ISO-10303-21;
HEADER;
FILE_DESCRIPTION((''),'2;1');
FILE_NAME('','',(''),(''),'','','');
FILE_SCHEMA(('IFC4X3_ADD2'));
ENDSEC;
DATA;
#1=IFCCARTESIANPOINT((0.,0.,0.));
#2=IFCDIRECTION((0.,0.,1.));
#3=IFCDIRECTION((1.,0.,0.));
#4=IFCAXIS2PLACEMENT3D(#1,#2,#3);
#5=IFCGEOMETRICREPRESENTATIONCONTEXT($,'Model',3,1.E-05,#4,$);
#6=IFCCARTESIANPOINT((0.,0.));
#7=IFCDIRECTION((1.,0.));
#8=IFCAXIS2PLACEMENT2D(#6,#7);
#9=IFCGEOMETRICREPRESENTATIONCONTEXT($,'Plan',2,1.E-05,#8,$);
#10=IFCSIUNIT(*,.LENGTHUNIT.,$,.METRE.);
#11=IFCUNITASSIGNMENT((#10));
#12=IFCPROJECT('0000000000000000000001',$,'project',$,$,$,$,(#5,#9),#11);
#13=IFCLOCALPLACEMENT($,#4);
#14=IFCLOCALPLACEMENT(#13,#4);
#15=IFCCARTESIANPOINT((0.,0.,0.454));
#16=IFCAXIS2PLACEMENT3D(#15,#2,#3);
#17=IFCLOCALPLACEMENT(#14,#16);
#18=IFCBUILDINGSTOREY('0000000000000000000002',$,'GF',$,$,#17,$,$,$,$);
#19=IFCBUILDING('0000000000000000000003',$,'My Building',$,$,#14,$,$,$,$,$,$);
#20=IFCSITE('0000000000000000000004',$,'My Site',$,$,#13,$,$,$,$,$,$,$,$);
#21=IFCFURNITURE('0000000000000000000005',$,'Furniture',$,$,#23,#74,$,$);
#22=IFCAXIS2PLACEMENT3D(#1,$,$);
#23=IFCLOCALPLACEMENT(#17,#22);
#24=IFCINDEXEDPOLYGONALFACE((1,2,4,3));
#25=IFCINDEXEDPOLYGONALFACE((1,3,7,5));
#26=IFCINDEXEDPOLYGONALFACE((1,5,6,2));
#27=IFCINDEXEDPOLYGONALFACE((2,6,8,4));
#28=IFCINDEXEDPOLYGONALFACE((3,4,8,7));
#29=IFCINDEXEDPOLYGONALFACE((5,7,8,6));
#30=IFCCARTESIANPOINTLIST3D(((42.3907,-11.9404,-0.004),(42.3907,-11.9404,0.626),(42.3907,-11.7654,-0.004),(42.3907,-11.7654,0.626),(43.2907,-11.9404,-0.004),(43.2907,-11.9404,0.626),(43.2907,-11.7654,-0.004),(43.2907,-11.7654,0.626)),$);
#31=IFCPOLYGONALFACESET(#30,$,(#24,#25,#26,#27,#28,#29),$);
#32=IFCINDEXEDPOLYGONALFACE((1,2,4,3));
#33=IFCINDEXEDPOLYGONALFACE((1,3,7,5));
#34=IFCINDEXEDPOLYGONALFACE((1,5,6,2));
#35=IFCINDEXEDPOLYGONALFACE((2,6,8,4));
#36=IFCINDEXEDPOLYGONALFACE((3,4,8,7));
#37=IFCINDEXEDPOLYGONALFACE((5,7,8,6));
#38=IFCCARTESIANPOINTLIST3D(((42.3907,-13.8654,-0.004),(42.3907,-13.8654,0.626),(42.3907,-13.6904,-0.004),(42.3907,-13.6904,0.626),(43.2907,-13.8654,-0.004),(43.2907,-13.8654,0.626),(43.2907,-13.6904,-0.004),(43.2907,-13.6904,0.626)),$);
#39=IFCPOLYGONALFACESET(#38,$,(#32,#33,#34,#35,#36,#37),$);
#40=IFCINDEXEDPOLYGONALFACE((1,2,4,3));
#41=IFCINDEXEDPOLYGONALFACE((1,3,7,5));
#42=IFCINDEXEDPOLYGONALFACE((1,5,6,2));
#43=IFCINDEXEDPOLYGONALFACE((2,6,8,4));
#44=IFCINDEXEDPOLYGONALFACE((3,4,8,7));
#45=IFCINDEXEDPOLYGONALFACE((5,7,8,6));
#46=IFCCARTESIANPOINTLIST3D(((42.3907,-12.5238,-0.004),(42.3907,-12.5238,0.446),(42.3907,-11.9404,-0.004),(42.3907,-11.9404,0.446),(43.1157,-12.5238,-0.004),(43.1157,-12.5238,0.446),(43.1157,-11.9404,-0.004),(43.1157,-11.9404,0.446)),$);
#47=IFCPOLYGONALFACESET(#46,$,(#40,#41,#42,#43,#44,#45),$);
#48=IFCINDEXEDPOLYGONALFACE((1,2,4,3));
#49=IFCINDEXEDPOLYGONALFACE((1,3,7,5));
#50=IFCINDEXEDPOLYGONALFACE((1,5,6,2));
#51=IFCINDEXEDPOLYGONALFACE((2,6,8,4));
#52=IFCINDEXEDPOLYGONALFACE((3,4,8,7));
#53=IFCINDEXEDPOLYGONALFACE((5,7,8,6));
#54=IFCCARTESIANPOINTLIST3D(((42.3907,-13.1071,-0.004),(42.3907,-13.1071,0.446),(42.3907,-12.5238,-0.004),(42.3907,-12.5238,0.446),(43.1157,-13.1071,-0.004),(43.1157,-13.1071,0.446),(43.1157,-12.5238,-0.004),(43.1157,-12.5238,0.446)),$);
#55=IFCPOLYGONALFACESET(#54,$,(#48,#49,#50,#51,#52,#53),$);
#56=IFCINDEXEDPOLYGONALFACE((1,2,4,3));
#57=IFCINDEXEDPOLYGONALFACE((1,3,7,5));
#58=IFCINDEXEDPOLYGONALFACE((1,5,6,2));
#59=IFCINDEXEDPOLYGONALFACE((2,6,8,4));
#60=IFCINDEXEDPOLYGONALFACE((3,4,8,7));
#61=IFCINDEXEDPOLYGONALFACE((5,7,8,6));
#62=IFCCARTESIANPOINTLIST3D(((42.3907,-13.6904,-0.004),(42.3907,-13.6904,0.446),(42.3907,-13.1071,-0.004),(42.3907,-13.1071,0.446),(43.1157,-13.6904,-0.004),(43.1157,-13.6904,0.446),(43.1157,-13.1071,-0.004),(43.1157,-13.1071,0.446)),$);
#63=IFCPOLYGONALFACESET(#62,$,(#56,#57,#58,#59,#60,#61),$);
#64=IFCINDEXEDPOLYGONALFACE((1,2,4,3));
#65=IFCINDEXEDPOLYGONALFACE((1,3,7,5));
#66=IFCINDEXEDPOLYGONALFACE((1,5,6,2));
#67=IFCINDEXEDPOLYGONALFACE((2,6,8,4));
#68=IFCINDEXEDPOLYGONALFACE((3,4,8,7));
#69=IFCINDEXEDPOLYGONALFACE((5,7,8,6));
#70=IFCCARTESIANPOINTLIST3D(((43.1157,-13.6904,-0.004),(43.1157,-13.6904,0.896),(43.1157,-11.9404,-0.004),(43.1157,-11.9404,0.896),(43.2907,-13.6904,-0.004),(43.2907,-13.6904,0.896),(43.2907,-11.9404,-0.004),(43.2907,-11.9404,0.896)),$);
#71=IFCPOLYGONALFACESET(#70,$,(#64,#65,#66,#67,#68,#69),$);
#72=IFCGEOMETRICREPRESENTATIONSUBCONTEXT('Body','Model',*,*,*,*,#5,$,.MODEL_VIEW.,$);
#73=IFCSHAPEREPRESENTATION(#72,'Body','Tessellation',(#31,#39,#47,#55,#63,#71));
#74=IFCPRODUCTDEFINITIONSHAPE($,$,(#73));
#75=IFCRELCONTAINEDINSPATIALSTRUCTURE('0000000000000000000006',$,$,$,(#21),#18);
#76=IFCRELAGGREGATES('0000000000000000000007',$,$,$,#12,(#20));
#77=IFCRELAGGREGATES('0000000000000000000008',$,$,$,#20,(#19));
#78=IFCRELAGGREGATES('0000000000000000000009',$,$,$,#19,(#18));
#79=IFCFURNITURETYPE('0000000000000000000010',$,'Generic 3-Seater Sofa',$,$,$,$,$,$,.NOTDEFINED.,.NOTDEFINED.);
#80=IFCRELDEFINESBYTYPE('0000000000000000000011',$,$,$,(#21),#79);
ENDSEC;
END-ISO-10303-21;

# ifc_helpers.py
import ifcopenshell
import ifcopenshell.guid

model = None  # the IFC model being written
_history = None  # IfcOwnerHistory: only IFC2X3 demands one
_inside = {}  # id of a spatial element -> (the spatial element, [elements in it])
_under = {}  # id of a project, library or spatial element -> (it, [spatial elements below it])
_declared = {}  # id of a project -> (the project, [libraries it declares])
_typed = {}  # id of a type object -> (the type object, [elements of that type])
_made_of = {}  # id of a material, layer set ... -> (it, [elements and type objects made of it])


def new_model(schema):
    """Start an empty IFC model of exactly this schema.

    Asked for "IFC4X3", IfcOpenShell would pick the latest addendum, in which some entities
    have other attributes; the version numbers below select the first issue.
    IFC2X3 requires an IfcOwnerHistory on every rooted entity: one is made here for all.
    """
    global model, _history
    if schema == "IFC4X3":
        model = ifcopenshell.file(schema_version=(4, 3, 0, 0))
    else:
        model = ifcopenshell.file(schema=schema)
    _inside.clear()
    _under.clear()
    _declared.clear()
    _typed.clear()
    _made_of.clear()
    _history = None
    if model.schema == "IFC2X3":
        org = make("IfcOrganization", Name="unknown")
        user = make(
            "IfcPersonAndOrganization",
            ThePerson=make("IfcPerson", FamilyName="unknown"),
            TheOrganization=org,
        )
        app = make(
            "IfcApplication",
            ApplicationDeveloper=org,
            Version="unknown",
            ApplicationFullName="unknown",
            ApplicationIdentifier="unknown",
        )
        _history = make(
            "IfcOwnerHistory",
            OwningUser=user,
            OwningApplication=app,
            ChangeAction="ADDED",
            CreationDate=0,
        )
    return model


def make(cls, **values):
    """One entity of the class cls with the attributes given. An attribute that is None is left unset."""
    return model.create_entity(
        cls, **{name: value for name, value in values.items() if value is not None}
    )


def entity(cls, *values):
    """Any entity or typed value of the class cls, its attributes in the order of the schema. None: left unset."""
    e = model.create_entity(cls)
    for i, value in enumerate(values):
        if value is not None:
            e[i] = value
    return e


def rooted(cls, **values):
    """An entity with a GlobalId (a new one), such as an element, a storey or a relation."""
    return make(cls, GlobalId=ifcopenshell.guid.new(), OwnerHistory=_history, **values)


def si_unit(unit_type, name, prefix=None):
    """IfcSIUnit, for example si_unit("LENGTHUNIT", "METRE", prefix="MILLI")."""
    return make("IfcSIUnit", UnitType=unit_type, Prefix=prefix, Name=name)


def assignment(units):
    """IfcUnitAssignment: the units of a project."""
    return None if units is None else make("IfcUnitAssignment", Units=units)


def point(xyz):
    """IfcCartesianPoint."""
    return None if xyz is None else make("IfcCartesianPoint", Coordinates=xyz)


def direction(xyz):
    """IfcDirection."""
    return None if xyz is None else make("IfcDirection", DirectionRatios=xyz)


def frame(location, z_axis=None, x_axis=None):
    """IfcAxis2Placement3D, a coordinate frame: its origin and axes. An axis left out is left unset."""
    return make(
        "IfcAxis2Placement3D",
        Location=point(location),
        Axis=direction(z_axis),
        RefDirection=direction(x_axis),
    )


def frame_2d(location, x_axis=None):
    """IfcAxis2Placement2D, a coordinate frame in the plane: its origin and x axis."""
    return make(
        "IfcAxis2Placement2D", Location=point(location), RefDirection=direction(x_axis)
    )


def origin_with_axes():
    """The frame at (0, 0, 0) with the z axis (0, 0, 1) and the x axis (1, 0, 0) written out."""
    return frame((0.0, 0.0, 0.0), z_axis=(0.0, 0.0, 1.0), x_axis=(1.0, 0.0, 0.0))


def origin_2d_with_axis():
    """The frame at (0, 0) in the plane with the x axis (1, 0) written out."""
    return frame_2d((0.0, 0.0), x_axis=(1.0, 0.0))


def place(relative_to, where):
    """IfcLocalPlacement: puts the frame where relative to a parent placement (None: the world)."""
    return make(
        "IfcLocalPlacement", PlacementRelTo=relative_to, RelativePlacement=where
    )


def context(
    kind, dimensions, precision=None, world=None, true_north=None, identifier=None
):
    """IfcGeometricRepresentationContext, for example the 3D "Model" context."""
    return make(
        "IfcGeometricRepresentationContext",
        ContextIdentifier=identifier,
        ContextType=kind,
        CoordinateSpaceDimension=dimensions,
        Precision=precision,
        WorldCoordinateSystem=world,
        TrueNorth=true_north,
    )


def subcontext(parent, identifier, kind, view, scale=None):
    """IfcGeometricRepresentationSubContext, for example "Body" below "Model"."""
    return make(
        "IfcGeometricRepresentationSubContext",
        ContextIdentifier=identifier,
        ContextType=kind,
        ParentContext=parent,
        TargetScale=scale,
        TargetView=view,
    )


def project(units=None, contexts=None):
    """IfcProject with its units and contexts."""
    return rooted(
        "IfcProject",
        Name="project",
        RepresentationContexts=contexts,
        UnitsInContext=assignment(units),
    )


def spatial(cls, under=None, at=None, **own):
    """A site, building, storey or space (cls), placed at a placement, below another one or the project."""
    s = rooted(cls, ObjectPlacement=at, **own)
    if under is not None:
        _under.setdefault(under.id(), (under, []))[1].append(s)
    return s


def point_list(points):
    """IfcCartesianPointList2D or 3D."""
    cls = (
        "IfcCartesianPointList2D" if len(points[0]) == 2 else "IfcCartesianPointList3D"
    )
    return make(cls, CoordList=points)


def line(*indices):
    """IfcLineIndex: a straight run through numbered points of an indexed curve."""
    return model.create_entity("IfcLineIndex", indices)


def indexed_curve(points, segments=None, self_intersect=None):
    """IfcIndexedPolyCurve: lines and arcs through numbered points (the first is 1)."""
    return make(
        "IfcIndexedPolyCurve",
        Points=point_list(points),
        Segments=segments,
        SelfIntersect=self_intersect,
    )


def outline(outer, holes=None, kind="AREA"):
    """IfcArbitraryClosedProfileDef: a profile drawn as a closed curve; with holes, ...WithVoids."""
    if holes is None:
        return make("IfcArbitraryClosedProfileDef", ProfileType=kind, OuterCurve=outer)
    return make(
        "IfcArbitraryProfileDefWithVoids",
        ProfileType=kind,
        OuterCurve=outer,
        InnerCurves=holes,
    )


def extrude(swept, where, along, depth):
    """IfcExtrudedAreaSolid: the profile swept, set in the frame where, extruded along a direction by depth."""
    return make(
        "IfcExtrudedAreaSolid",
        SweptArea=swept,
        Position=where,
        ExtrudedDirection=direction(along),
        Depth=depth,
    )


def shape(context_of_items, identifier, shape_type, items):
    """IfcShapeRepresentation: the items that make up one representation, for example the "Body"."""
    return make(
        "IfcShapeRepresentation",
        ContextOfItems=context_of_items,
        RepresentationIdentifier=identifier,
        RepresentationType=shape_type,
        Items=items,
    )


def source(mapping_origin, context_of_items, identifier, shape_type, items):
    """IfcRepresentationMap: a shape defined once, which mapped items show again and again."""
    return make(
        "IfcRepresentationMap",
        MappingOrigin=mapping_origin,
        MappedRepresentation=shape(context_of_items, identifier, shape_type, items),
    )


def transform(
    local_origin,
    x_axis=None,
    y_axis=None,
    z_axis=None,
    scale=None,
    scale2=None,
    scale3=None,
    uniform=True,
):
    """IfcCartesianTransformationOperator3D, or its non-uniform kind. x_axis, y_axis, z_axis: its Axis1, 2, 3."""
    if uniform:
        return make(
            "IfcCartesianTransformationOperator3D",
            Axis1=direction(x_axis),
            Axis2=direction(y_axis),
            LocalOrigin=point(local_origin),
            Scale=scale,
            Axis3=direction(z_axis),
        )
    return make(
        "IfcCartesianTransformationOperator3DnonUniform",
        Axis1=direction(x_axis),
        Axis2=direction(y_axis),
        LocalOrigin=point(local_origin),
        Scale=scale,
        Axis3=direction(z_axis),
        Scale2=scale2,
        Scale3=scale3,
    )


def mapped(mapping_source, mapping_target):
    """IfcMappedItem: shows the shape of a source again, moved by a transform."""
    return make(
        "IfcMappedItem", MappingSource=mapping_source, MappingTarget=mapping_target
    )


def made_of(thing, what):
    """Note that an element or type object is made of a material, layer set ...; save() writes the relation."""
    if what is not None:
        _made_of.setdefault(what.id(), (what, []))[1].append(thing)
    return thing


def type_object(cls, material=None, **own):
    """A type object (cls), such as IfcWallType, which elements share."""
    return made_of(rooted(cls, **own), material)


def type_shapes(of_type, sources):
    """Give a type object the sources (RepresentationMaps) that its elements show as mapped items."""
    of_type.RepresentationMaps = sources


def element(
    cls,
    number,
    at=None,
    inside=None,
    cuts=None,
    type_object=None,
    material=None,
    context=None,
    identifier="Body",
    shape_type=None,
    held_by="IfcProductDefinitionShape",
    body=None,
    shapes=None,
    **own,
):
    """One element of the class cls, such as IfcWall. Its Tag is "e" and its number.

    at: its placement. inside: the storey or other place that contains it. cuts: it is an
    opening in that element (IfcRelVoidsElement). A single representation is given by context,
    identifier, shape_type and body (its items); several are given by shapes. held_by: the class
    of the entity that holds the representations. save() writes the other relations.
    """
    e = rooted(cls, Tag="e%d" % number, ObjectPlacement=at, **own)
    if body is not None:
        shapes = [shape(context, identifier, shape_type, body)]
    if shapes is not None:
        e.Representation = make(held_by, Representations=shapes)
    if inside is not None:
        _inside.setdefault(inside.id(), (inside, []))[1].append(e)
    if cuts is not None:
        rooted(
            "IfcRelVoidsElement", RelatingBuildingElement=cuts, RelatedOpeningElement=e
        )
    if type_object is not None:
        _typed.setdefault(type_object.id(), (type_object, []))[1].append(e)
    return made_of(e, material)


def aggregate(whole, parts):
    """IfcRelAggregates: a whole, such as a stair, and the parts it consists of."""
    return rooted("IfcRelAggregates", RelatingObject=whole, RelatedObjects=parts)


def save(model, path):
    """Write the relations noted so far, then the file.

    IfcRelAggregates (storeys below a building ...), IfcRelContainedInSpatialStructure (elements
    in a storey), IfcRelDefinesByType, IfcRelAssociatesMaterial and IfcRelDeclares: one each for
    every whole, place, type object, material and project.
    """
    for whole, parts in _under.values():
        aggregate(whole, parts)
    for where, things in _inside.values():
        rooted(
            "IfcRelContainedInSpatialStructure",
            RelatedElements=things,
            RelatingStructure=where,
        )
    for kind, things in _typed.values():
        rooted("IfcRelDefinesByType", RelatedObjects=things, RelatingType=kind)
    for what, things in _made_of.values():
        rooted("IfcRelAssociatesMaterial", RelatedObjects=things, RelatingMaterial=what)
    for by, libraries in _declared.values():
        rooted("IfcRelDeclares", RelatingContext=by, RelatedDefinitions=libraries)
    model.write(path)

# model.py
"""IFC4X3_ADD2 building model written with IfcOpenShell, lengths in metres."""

from ifc_helpers import new_model, entity, si_unit, frame, origin_with_axes, origin_2d_with_axis, place, context, subcontext, project, spatial, line, indexed_curve, outline, extrude, shape, source, transform, mapped, type_object, type_shapes, element, save


model = new_model("IFC4X3_ADD2")

# Units and contexts
model_context = context("Model", 3, precision=1e-05, world=origin_with_axes())
plan_context = context("Plan", 2, precision=1e-05, world=origin_2d_with_axis())
body_context_1 = subcontext(model_context, "Body", "Model", "MODEL_VIEW")
body_context_2 = subcontext(plan_context, "Body", "Plan", "PLAN_VIEW")
ifc_project = project(units=[si_unit("LENGTHUNIT", "METRE")], contexts=[model_context, plan_context])

# Site, building, storey
site_placement = place(None, origin_with_axes())
site = spatial("IfcSite", under=ifc_project, at=site_placement, Name="My Site")
building_placement = place(site_placement, origin_with_axes())
building = spatial("IfcBuilding", under=site, at=building_placement, Name="My Building")
storey_placement = place(building_placement, frame((0.0, 0.0, 0.454), z_axis=(0.0, 0.0, 1.0), x_axis=(1.0, 0.0, 0.0)))
storey = spatial("IfcBuildingStorey", under=building, at=storey_placement, Name="GF")

# Furniture
furniture_type_1 = type_object("IfcFurnitureType", Name="Generic 3-Seater Sofa", AssemblyPlace="NOTDEFINED", PredefinedType="NOTDEFINED")
shared_shape_1 = source(origin_with_axes(), body_context_1, "Body", "SweptSolid", [
    extrude(outline(indexed_curve([(0.0, 0.0), (0.175, 0.0), (0.175, 0.9), (0.0, 0.9)], segments=[line(4, 1), line(1, 2), line(2, 3), line(3, 4)], self_intersect=False)), frame((-1.05, -0.9, 0.0), z_axis=(0.0, 0.0, 1.0), x_axis=(1.0, 0.0, 0.0)), (0.0, 0.0, 1.0), 0.63),
    extrude(outline(indexed_curve([(0.0, 0.0), (0.175, 0.0), (0.175, 0.9), (0.0, 0.9)], segments=[line(1, 2, 3, 4, 1)])), frame((0.875, -0.9, 0.0), z_axis=(0.0, 0.0, 1.0), x_axis=(1.0, 0.0, 0.0)), (0.0, 0.0, 1.0), 0.63),
    extrude(outline(indexed_curve([(0.175, 0.0), (0.7583, 0.0), (0.7583, 0.725), (0.175, 0.725)], segments=[line(1, 2, 3, 4, 1)])), frame((-1.05, -0.9, 0.0), z_axis=(0.0, 0.0, 1.0), x_axis=(1.0, 0.0, 0.0)), (0.0, 0.0, 1.0), 0.45),
    extrude(outline(indexed_curve([(0.7583, 0.0), (1.3417, 0.0), (1.3417, 0.725), (0.7583, 0.725)], segments=[line(1, 2, 3, 4, 1)])), frame((-1.05, -0.9, 0.0), z_axis=(0.0, 0.0, 1.0), x_axis=(1.0, 0.0, 0.0)), (0.0, 0.0, 1.0), 0.45),
    extrude(outline(indexed_curve([(1.3417, 0.0), (1.925, 0.0), (1.925, 0.725), (1.3417, 0.725)], segments=[line(1, 2, 3, 4, 1)])), frame((-1.05, -0.9, 0.0), z_axis=(0.0, 0.0, 1.0), x_axis=(1.0, 0.0, 0.0)), (0.0, 0.0, 1.0), 0.45),
    extrude(outline(indexed_curve([(0.175, 0.725), (1.925, 0.725), (1.925, 0.9), (0.175, 0.9)], segments=[line(1, 2, 3, 4, 1)])), frame((-1.05, -0.9, 0.0), z_axis=(0.0, 0.0, 1.0), x_axis=(1.0, 0.0, 0.0)), (0.0, 0.0, 1.0), 0.9),
])
shared_shape_2 = source(origin_with_axes(), body_context_2, "Body", "Annotation2D", [
    entity("IfcGeometricCurveSet", [entity("IfcIndexedPolyCurve", entity("IfcCartesianPointList2D", [[0.2917, -0.175], [0.2917, -0.9], [0.875, -0.9], [0.875, -0.175], [-0.875, -0.175], [-0.875, 0.0], [0.875, 0.0], [1.05, 0.0], [1.05, -0.9], [0.875, -0.9], [0.875, 0.0], [0.875, -0.175], [0.2917, -0.175], [-0.2917, -0.175], [-0.2917, -0.9], [-0.875, -0.9], [-0.875, 0.0], [-1.05, 0.0], [-1.05, -0.9], [-0.875, -0.9], [-0.875, -0.175], [-0.2917, -0.175]])), entity("IfcIndexedPolyCurve", entity("IfcCartesianPointList2D", [[0.2917, -0.9], [-0.2917, -0.9]]))]),
])
type_shapes(furniture_type_1, [shared_shape_1, shared_shape_2])
furniture_placement = place(storey_placement, frame((43.2907, -12.8154, -0.004), z_axis=(0.0, 0.0, 1.0), x_axis=(0.0, -1.0, 0.0)))
element("IfcFurniture", 1, at=furniture_placement, inside=storey, type_object=furniture_type_1, Name="Furniture", shapes=[
    shape(body_context_1, "Body", "MappedRepresentation", [mapped(shared_shape_1, transform((0.0, 0.0, 0.0), x_axis=(1.0, 0.0, 0.0), y_axis=(0.0, 1.0, 0.0), z_axis=(0.0, 0.0, 1.0), scale=1.0))]),
    shape(body_context_2, "Body", "MappedRepresentation", [mapped(shared_shape_2, transform((0.0, 0.0, 0.0), x_axis=(1.0, 0.0, 0.0), y_axis=(0.0, 1.0, 0.0), z_axis=(0.0, 0.0, 1.0), scale=1.0))]),
])

save(model, "model.ifc")
